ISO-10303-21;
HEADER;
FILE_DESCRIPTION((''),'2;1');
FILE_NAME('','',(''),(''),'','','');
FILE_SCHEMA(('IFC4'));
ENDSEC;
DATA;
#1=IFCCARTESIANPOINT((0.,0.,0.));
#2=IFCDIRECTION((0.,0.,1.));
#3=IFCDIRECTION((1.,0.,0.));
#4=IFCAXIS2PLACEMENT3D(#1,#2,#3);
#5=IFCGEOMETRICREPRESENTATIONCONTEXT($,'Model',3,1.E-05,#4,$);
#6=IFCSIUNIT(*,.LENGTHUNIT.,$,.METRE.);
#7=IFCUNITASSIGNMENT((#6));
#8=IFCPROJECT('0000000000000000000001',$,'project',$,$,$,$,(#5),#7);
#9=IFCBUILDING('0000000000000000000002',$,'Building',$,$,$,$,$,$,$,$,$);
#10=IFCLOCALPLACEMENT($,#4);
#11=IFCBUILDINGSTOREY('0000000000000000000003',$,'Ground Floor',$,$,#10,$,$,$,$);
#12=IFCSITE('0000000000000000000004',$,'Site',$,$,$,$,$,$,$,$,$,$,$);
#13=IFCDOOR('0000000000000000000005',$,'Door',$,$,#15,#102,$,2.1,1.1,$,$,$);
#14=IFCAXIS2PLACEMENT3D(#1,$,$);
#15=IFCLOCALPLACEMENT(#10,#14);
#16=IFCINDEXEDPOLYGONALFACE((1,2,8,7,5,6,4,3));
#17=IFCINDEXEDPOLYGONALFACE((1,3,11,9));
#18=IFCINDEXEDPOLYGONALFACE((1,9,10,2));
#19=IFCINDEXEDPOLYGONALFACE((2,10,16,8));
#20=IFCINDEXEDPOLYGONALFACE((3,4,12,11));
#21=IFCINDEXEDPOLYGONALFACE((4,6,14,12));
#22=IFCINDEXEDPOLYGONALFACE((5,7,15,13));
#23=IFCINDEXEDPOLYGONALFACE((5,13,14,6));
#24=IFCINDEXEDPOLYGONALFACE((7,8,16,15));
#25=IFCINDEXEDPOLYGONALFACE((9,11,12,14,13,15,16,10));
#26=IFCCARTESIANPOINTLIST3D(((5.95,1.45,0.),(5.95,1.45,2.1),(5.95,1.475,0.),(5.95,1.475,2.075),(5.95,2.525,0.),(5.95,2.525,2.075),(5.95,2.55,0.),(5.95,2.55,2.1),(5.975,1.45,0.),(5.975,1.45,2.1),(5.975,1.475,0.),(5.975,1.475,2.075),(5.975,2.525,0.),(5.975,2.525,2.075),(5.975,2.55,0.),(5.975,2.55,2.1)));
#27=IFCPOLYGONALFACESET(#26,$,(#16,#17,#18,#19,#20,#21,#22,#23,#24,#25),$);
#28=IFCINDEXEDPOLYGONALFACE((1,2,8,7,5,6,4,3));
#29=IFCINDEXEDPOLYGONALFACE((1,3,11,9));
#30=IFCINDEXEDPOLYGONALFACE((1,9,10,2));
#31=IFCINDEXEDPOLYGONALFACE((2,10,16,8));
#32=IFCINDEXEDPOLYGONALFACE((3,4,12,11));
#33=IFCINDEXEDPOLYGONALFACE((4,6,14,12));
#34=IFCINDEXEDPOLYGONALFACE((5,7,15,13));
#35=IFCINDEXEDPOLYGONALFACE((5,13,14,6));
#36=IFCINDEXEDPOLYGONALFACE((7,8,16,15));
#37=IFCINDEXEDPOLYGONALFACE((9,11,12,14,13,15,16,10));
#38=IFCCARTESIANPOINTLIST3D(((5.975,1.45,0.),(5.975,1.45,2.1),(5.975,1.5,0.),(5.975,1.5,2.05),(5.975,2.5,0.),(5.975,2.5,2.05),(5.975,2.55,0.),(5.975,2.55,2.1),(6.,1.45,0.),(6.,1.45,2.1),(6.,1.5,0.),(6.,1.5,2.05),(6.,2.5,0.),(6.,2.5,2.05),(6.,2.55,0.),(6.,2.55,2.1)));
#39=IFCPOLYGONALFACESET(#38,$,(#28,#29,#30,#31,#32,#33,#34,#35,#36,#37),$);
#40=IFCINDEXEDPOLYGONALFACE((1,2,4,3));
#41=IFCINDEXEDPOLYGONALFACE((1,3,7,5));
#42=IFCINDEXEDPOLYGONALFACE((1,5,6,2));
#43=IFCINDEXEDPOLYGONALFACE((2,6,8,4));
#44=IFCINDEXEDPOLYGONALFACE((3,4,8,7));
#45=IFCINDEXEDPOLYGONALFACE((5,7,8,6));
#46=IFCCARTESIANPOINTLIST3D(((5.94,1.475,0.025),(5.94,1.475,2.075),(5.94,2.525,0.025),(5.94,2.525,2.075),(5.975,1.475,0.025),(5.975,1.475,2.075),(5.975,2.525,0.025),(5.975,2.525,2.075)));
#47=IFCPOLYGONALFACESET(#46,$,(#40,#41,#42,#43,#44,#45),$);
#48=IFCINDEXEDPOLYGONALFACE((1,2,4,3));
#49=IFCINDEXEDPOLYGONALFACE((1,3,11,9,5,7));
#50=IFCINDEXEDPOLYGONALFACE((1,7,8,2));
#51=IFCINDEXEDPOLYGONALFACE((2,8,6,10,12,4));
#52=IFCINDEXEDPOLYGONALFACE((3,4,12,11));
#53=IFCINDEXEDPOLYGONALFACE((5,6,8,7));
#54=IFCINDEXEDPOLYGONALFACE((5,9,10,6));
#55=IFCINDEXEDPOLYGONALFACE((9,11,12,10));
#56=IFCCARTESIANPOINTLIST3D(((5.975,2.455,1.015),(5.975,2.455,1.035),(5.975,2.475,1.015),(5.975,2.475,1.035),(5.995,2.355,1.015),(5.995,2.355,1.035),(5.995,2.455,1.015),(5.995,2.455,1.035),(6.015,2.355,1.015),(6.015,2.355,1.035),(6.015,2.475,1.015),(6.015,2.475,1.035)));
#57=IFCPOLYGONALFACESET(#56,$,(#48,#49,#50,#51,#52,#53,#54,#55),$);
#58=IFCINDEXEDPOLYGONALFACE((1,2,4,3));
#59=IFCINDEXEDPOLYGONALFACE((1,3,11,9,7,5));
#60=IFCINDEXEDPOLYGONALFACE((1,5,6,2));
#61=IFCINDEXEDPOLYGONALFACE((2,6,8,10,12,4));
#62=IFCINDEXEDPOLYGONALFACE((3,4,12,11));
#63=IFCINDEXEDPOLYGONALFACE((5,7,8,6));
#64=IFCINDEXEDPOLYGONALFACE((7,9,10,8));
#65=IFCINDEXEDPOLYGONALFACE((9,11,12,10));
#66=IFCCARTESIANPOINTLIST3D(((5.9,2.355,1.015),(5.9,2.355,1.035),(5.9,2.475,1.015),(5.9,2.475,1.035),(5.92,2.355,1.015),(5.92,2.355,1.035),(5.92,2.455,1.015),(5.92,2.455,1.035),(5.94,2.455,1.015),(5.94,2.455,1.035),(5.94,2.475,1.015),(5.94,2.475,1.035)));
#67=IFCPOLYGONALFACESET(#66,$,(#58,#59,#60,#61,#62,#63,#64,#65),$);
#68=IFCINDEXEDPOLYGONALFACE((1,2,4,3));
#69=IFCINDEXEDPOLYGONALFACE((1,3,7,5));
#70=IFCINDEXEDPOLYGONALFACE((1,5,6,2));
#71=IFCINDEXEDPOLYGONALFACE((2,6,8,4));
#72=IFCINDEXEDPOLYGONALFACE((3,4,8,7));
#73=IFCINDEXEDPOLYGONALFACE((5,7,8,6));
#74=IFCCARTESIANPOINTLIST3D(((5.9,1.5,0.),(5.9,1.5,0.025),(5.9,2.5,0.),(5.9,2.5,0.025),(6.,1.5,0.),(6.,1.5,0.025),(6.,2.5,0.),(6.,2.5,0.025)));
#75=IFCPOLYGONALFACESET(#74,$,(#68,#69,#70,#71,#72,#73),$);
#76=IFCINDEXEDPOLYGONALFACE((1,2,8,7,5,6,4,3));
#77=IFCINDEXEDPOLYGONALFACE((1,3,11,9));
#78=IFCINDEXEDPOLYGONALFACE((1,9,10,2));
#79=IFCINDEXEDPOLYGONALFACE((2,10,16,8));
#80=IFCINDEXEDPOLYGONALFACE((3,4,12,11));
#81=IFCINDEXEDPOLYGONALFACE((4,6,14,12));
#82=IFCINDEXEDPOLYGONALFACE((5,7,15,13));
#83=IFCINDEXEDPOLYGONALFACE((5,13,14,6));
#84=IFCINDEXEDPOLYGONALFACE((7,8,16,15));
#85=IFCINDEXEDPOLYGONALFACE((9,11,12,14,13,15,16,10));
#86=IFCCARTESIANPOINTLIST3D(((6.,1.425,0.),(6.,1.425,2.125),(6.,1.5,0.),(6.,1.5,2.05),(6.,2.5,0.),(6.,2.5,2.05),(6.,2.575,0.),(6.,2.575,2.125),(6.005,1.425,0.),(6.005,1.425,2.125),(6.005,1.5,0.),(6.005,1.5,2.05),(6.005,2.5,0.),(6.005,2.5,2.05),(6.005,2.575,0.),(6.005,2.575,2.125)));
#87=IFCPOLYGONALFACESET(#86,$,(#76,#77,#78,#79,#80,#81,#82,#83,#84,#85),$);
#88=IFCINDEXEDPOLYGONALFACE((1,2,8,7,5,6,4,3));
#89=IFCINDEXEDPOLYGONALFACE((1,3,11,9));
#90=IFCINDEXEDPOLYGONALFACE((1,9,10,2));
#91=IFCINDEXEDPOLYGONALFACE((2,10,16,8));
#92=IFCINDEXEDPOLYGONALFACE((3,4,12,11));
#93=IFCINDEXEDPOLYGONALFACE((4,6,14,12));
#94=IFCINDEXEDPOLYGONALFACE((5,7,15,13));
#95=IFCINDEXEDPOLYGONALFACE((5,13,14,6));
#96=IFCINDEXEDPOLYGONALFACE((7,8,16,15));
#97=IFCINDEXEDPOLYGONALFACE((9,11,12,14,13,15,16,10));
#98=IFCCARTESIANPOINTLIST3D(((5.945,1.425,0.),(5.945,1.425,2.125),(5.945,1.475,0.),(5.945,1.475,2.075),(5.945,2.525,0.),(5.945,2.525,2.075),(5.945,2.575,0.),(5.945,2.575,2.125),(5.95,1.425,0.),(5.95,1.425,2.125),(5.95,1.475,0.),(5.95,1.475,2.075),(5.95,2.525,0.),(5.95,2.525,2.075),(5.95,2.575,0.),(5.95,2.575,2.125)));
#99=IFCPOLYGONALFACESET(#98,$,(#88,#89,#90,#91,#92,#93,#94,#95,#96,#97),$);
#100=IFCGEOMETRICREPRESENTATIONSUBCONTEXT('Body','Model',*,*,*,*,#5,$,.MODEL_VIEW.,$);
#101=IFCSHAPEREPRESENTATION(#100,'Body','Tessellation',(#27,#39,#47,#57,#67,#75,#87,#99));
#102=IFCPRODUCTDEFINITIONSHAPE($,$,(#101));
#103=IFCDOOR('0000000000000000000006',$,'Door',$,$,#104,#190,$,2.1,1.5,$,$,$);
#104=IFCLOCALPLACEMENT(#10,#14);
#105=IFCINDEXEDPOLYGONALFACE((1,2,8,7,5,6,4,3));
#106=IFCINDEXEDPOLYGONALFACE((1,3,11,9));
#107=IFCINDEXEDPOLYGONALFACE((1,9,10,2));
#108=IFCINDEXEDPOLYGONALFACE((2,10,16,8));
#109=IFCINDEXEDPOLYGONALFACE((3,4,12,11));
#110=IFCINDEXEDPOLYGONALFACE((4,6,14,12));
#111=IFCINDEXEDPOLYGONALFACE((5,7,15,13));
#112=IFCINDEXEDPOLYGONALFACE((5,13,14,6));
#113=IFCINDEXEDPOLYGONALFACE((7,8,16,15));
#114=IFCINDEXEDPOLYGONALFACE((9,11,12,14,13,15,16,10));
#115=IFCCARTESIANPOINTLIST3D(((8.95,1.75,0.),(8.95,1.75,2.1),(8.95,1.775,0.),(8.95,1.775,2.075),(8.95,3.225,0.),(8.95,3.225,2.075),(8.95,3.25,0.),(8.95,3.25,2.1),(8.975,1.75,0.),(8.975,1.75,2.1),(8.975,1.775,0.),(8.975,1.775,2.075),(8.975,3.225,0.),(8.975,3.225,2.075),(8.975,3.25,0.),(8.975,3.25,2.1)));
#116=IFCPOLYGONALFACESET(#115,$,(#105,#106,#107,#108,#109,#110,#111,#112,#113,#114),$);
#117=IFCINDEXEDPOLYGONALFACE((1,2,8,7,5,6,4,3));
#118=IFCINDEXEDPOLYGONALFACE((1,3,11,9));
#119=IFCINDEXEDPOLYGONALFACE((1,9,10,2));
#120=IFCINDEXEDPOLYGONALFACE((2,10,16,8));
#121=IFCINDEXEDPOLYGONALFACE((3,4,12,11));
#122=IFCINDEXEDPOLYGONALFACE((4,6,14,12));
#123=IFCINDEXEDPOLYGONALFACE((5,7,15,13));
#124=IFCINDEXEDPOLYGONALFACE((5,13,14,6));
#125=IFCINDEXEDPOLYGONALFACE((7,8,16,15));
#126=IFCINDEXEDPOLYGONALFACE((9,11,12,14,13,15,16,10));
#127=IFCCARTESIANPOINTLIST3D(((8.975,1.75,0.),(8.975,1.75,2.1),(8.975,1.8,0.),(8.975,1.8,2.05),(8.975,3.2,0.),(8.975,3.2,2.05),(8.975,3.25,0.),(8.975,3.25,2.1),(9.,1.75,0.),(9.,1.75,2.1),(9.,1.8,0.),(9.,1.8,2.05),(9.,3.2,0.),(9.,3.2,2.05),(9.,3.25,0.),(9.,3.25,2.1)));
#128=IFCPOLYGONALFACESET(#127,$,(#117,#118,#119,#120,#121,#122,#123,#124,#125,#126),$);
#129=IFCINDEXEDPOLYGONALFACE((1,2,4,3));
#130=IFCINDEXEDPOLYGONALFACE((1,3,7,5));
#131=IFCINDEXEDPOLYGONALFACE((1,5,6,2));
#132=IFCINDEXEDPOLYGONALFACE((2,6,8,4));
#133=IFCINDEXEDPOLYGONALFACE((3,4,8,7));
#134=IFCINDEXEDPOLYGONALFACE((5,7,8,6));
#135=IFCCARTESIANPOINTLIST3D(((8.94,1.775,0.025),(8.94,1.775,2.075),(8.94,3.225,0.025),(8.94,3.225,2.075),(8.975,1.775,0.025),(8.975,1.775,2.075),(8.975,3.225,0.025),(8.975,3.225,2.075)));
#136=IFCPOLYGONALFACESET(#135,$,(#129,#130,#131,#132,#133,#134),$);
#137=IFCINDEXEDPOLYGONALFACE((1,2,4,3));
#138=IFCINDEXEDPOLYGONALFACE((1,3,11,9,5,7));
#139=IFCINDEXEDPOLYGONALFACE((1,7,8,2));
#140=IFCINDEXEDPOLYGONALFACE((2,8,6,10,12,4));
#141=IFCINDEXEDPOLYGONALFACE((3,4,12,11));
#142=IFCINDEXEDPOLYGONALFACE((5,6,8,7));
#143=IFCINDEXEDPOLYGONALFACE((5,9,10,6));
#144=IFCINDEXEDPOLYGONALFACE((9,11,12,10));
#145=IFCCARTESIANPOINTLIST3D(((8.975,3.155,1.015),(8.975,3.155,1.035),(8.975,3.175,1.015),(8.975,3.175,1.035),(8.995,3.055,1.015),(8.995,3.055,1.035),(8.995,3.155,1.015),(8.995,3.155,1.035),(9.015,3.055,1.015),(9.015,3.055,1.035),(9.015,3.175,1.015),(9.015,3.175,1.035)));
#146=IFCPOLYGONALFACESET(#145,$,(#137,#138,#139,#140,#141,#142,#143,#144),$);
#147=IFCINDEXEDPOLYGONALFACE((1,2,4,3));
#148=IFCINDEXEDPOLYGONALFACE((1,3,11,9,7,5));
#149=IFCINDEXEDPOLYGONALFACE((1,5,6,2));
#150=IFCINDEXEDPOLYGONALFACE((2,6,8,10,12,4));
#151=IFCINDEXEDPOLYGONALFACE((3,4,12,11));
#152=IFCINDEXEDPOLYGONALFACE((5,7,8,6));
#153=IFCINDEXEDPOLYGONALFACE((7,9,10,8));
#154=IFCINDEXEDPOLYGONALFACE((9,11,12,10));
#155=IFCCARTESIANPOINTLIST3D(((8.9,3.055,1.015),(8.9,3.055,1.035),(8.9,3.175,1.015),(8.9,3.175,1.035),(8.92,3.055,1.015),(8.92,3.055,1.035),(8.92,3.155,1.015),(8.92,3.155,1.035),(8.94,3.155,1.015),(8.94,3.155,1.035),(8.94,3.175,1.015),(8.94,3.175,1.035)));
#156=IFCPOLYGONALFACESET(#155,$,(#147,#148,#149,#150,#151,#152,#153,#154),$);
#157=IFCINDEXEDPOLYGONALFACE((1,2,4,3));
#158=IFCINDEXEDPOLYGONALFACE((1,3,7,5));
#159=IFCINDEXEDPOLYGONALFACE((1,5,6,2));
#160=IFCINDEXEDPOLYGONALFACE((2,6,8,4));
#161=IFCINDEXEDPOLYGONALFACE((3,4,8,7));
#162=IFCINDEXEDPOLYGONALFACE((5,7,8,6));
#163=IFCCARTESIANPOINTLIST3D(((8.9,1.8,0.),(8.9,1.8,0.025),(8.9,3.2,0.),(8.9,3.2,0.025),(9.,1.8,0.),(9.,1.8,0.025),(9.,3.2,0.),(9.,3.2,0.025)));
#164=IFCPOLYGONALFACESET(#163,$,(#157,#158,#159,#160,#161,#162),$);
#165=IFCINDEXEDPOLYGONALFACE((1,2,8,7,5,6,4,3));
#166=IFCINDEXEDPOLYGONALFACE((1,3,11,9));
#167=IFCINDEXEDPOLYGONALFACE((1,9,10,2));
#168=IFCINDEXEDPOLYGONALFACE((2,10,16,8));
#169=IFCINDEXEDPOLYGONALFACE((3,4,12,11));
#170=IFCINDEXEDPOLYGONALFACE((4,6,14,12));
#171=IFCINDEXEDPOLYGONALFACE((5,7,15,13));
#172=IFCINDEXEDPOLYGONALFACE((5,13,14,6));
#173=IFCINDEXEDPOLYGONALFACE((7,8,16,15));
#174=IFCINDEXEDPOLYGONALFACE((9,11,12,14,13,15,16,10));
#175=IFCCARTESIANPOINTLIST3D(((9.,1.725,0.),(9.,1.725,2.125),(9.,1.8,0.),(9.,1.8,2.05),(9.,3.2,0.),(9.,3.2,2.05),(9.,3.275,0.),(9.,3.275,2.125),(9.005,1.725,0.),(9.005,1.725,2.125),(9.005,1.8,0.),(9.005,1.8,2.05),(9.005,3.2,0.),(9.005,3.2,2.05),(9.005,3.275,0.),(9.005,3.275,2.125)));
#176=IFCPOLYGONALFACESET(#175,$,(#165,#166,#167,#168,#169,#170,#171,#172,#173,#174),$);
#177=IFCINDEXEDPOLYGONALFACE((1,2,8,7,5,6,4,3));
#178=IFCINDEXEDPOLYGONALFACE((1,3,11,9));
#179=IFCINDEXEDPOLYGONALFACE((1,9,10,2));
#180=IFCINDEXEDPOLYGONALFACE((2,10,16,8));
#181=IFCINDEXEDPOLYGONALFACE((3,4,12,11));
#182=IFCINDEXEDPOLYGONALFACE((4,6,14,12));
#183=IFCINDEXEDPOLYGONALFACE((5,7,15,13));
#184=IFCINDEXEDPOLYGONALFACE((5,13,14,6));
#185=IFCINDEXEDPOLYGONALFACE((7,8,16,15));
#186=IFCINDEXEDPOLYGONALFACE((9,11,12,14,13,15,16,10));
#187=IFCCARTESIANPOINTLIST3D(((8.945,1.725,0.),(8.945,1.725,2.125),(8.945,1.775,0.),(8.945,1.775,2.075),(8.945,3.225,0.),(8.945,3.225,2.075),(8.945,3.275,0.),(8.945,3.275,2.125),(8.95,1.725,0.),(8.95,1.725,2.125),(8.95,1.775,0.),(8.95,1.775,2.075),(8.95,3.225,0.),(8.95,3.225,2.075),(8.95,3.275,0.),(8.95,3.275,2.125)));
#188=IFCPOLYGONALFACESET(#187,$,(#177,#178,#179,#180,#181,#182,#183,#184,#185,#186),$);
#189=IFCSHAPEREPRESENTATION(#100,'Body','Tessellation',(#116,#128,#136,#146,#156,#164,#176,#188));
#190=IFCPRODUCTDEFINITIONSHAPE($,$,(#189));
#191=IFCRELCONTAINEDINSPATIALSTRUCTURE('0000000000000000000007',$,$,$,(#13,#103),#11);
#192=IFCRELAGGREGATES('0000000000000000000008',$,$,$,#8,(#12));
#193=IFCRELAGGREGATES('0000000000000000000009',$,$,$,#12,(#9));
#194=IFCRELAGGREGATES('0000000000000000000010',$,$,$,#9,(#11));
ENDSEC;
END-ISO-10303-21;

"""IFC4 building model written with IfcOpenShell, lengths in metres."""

from ifc_helpers import new_model, si_unit, frame, origin_with_axes, place, context, subcontext, project, spatial, line, indexed_curve, outline, extrude, element, save


model = new_model("IFC4")

# Units and contexts
model_context = context("Model", 3, precision=1e-05, world=origin_with_axes())
body_context = subcontext(model_context, "Body", "Model", "MODEL_VIEW")
ifc_project = project(units=[si_unit("LENGTHUNIT", "METRE")], contexts=[model_context])

# Site, building, storey
site = spatial("IfcSite", under=ifc_project, Name="Site")
building = spatial("IfcBuilding", under=site, Name="Building")
storey_placement = place(None, origin_with_axes())
storey = spatial("IfcBuildingStorey", under=building, at=storey_placement, Name="Ground Floor")

# Doors
door_1_placement = place(storey_placement, frame((6.0, 1.45, 0.0), z_axis=(0.0, 0.0, 1.0), x_axis=(0.0, 1.0, 0.0)))
element("IfcDoor", 1, at=door_1_placement, inside=storey, Name="Door", OverallHeight=2.1, OverallWidth=1.1, context=body_context, shape_type="SweptSolid", body=[
    extrude(outline(indexed_curve([(0.0, 0.0), (0.0, 2.1), (1.1, 2.1), (1.1, 0.0), (1.075, 0.0), (1.075, 2.075), (0.025, 2.075), (0.025, 0.0)], segments=[line(1, 2, 3, 4, 5, 6, 7, 8, 1)])), frame((0.0, 0.025, 0.0), z_axis=(0.0, -1.0, 0.0), x_axis=(1.0, 0.0, 0.0)), (0.0, 0.0, -1.0), 0.025),
    extrude(outline(indexed_curve([(0.0, 0.0), (0.0, 2.1), (1.1, 2.1), (1.1, 0.0), (1.05, 0.0), (1.05, 2.05), (0.05, 2.05), (0.05, 0.0)], segments=[line(1, 2, 3, 4, 5, 6, 7, 8, 1)])), frame((0.0, 0.0, 0.0), z_axis=(0.0, -1.0, 0.0), x_axis=(1.0, 0.0, 0.0)), (0.0, 0.0, -1.0), 0.025),
    extrude(outline(indexed_curve([(0.0, 0.0), (1.05, 0.0), (1.05, 0.035), (0.0, 0.035)], segments=[line(1, 2, 3, 4, 1)])), frame((0.025, 0.025, 0.025), z_axis=(0.0, 0.0, 1.0), x_axis=(1.0, 0.0, 0.0)), (0.0, 0.0, 1.0), 2.05),
    extrude(outline(indexed_curve([(0.0, 0.0), (0.0, -0.04), (-0.12, -0.04), (-0.12, -0.02), (-0.02, -0.02), (-0.02, 0.0)], segments=[line(1, 2, 3, 4, 5, 6, 1)])), frame((1.025, 0.025, 1.015), z_axis=(0.0, 0.0, 1.0), x_axis=(1.0, 0.0, 0.0)), (0.0, 0.0, 1.0), 0.02),
    extrude(outline(indexed_curve([(0.0, 0.0), (0.0, 0.04), (-0.12, 0.04), (-0.12, 0.02), (-0.02, 0.02), (-0.02, 0.0)], segments=[line(1, 2, 3, 4, 5, 6, 1)])), frame((1.025, 0.06, 1.015), z_axis=(0.0, 0.0, 1.0), x_axis=(1.0, 0.0, 0.0)), (0.0, 0.0, 1.0), 0.02),
    extrude(outline(indexed_curve([(0.0, 0.0), (1.0, 0.0), (1.0, 0.1), (0.0, 0.1)], segments=[line(1, 2, 3, 4, 1)])), frame((0.05, 0.0, 0.0), z_axis=(0.0, 0.0, 1.0), x_axis=(1.0, 0.0, 0.0)), (0.0, 0.0, 1.0), 0.025),
    extrude(outline(indexed_curve([(0.0, 0.0), (0.0, 2.125), (1.15, 2.125), (1.15, 0.0), (1.075, 0.0), (1.075, 2.05), (0.075, 2.05), (0.075, 0.0)], segments=[line(1, 2, 3, 4, 5, 6, 7, 8, 1)])), frame((-0.025, -0.005, 0.0), z_axis=(0.0, -1.0, 0.0), x_axis=(1.0, 0.0, 0.0)), (0.0, 0.0, -1.0), 0.005),
    extrude(outline(indexed_curve([(0.0, 0.0), (0.0, 2.125), (1.15, 2.125), (1.15, 0.0), (1.1, 0.0), (1.1, 2.075), (0.05, 2.075), (0.05, 0.0)], segments=[line(1, 2, 3, 4, 5, 6, 7, 8, 1)])), frame((-0.025, 0.05, 0.0), z_axis=(0.0, -1.0, 0.0), x_axis=(1.0, 0.0, 0.0)), (0.0, 0.0, -1.0), 0.005),
])
door_2_placement = place(storey_placement, frame((9.0, 1.75, 0.0), z_axis=(0.0, 0.0, 1.0), x_axis=(0.0, 1.0, 0.0)))
element("IfcDoor", 2, at=door_2_placement, inside=storey, Name="Door", OverallHeight=2.1, OverallWidth=1.5, context=body_context, shape_type="SweptSolid", body=[
    extrude(outline(indexed_curve([(0.0, 0.0), (0.0, 2.1), (1.5, 2.1), (1.5, 0.0), (1.475, 0.0), (1.475, 2.075), (0.025, 2.075), (0.025, 0.0)], segments=[line(1, 2, 3, 4, 5, 6, 7, 8, 1)])), frame((0.0, 0.025, 0.0), z_axis=(0.0, -1.0, 0.0), x_axis=(1.0, 0.0, 0.0)), (0.0, 0.0, -1.0), 0.025),
    extrude(outline(indexed_curve([(0.0, 0.0), (0.0, 2.1), (1.5, 2.1), (1.5, 0.0), (1.45, 0.0), (1.45, 2.05), (0.05, 2.05), (0.05, 0.0)], segments=[line(1, 2, 3, 4, 5, 6, 7, 8, 1)])), frame((0.0, 0.0, 0.0), z_axis=(0.0, -1.0, 0.0), x_axis=(1.0, 0.0, 0.0)), (0.0, 0.0, -1.0), 0.025),
    extrude(outline(indexed_curve([(0.0, 0.0), (1.45, 0.0), (1.45, 0.035), (0.0, 0.035)], segments=[line(1, 2, 3, 4, 1)])), frame((0.025, 0.025, 0.025), z_axis=(0.0, 0.0, 1.0), x_axis=(1.0, 0.0, 0.0)), (0.0, 0.0, 1.0), 2.05),
    extrude(outline(indexed_curve([(0.0, 0.0), (0.0, -0.04), (-0.12, -0.04), (-0.12, -0.02), (-0.02, -0.02), (-0.02, 0.0)], segments=[line(1, 2, 3, 4, 5, 6, 1)])), frame((1.425, 0.025, 1.015), z_axis=(0.0, 0.0, 1.0), x_axis=(1.0, 0.0, 0.0)), (0.0, 0.0, 1.0), 0.02),
    extrude(outline(indexed_curve([(0.0, 0.0), (0.0, 0.04), (-0.12, 0.04), (-0.12, 0.02), (-0.02, 0.02), (-0.02, 0.0)], segments=[line(1, 2, 3, 4, 5, 6, 1)])), frame((1.425, 0.06, 1.015), z_axis=(0.0, 0.0, 1.0), x_axis=(1.0, 0.0, 0.0)), (0.0, 0.0, 1.0), 0.02),
    extrude(outline(indexed_curve([(0.0, 0.0), (1.4, 0.0), (1.4, 0.1), (0.0, 0.1)], segments=[line(1, 2, 3, 4, 1)])), frame((0.05, 0.0, 0.0), z_axis=(0.0, 0.0, 1.0), x_axis=(1.0, 0.0, 0.0)), (0.0, 0.0, 1.0), 0.025),
    extrude(outline(indexed_curve([(0.0, 0.0), (0.0, 2.125), (1.55, 2.125), (1.55, 0.0), (1.475, 0.0), (1.475, 2.05), (0.075, 2.05), (0.075, 0.0)], segments=[line(1, 2, 3, 4, 5, 6, 7, 8, 1)])), frame((-0.025, -0.005, 0.0), z_axis=(0.0, -1.0, 0.0), x_axis=(1.0, 0.0, 0.0)), (0.0, 0.0, -1.0), 0.005),
    extrude(outline(indexed_curve([(0.0, 0.0), (0.0, 2.125), (1.55, 2.125), (1.55, 0.0), (1.5, 0.0), (1.5, 2.075), (0.05, 2.075), (0.05, 0.0)], segments=[line(1, 2, 3, 4, 5, 6, 7, 8, 1)])), frame((-0.025, 0.05, 0.0), z_axis=(0.0, -1.0, 0.0), x_axis=(1.0, 0.0, 0.0)), (0.0, 0.0, -1.0), 0.005),
])

save(model, "model.ifc")
